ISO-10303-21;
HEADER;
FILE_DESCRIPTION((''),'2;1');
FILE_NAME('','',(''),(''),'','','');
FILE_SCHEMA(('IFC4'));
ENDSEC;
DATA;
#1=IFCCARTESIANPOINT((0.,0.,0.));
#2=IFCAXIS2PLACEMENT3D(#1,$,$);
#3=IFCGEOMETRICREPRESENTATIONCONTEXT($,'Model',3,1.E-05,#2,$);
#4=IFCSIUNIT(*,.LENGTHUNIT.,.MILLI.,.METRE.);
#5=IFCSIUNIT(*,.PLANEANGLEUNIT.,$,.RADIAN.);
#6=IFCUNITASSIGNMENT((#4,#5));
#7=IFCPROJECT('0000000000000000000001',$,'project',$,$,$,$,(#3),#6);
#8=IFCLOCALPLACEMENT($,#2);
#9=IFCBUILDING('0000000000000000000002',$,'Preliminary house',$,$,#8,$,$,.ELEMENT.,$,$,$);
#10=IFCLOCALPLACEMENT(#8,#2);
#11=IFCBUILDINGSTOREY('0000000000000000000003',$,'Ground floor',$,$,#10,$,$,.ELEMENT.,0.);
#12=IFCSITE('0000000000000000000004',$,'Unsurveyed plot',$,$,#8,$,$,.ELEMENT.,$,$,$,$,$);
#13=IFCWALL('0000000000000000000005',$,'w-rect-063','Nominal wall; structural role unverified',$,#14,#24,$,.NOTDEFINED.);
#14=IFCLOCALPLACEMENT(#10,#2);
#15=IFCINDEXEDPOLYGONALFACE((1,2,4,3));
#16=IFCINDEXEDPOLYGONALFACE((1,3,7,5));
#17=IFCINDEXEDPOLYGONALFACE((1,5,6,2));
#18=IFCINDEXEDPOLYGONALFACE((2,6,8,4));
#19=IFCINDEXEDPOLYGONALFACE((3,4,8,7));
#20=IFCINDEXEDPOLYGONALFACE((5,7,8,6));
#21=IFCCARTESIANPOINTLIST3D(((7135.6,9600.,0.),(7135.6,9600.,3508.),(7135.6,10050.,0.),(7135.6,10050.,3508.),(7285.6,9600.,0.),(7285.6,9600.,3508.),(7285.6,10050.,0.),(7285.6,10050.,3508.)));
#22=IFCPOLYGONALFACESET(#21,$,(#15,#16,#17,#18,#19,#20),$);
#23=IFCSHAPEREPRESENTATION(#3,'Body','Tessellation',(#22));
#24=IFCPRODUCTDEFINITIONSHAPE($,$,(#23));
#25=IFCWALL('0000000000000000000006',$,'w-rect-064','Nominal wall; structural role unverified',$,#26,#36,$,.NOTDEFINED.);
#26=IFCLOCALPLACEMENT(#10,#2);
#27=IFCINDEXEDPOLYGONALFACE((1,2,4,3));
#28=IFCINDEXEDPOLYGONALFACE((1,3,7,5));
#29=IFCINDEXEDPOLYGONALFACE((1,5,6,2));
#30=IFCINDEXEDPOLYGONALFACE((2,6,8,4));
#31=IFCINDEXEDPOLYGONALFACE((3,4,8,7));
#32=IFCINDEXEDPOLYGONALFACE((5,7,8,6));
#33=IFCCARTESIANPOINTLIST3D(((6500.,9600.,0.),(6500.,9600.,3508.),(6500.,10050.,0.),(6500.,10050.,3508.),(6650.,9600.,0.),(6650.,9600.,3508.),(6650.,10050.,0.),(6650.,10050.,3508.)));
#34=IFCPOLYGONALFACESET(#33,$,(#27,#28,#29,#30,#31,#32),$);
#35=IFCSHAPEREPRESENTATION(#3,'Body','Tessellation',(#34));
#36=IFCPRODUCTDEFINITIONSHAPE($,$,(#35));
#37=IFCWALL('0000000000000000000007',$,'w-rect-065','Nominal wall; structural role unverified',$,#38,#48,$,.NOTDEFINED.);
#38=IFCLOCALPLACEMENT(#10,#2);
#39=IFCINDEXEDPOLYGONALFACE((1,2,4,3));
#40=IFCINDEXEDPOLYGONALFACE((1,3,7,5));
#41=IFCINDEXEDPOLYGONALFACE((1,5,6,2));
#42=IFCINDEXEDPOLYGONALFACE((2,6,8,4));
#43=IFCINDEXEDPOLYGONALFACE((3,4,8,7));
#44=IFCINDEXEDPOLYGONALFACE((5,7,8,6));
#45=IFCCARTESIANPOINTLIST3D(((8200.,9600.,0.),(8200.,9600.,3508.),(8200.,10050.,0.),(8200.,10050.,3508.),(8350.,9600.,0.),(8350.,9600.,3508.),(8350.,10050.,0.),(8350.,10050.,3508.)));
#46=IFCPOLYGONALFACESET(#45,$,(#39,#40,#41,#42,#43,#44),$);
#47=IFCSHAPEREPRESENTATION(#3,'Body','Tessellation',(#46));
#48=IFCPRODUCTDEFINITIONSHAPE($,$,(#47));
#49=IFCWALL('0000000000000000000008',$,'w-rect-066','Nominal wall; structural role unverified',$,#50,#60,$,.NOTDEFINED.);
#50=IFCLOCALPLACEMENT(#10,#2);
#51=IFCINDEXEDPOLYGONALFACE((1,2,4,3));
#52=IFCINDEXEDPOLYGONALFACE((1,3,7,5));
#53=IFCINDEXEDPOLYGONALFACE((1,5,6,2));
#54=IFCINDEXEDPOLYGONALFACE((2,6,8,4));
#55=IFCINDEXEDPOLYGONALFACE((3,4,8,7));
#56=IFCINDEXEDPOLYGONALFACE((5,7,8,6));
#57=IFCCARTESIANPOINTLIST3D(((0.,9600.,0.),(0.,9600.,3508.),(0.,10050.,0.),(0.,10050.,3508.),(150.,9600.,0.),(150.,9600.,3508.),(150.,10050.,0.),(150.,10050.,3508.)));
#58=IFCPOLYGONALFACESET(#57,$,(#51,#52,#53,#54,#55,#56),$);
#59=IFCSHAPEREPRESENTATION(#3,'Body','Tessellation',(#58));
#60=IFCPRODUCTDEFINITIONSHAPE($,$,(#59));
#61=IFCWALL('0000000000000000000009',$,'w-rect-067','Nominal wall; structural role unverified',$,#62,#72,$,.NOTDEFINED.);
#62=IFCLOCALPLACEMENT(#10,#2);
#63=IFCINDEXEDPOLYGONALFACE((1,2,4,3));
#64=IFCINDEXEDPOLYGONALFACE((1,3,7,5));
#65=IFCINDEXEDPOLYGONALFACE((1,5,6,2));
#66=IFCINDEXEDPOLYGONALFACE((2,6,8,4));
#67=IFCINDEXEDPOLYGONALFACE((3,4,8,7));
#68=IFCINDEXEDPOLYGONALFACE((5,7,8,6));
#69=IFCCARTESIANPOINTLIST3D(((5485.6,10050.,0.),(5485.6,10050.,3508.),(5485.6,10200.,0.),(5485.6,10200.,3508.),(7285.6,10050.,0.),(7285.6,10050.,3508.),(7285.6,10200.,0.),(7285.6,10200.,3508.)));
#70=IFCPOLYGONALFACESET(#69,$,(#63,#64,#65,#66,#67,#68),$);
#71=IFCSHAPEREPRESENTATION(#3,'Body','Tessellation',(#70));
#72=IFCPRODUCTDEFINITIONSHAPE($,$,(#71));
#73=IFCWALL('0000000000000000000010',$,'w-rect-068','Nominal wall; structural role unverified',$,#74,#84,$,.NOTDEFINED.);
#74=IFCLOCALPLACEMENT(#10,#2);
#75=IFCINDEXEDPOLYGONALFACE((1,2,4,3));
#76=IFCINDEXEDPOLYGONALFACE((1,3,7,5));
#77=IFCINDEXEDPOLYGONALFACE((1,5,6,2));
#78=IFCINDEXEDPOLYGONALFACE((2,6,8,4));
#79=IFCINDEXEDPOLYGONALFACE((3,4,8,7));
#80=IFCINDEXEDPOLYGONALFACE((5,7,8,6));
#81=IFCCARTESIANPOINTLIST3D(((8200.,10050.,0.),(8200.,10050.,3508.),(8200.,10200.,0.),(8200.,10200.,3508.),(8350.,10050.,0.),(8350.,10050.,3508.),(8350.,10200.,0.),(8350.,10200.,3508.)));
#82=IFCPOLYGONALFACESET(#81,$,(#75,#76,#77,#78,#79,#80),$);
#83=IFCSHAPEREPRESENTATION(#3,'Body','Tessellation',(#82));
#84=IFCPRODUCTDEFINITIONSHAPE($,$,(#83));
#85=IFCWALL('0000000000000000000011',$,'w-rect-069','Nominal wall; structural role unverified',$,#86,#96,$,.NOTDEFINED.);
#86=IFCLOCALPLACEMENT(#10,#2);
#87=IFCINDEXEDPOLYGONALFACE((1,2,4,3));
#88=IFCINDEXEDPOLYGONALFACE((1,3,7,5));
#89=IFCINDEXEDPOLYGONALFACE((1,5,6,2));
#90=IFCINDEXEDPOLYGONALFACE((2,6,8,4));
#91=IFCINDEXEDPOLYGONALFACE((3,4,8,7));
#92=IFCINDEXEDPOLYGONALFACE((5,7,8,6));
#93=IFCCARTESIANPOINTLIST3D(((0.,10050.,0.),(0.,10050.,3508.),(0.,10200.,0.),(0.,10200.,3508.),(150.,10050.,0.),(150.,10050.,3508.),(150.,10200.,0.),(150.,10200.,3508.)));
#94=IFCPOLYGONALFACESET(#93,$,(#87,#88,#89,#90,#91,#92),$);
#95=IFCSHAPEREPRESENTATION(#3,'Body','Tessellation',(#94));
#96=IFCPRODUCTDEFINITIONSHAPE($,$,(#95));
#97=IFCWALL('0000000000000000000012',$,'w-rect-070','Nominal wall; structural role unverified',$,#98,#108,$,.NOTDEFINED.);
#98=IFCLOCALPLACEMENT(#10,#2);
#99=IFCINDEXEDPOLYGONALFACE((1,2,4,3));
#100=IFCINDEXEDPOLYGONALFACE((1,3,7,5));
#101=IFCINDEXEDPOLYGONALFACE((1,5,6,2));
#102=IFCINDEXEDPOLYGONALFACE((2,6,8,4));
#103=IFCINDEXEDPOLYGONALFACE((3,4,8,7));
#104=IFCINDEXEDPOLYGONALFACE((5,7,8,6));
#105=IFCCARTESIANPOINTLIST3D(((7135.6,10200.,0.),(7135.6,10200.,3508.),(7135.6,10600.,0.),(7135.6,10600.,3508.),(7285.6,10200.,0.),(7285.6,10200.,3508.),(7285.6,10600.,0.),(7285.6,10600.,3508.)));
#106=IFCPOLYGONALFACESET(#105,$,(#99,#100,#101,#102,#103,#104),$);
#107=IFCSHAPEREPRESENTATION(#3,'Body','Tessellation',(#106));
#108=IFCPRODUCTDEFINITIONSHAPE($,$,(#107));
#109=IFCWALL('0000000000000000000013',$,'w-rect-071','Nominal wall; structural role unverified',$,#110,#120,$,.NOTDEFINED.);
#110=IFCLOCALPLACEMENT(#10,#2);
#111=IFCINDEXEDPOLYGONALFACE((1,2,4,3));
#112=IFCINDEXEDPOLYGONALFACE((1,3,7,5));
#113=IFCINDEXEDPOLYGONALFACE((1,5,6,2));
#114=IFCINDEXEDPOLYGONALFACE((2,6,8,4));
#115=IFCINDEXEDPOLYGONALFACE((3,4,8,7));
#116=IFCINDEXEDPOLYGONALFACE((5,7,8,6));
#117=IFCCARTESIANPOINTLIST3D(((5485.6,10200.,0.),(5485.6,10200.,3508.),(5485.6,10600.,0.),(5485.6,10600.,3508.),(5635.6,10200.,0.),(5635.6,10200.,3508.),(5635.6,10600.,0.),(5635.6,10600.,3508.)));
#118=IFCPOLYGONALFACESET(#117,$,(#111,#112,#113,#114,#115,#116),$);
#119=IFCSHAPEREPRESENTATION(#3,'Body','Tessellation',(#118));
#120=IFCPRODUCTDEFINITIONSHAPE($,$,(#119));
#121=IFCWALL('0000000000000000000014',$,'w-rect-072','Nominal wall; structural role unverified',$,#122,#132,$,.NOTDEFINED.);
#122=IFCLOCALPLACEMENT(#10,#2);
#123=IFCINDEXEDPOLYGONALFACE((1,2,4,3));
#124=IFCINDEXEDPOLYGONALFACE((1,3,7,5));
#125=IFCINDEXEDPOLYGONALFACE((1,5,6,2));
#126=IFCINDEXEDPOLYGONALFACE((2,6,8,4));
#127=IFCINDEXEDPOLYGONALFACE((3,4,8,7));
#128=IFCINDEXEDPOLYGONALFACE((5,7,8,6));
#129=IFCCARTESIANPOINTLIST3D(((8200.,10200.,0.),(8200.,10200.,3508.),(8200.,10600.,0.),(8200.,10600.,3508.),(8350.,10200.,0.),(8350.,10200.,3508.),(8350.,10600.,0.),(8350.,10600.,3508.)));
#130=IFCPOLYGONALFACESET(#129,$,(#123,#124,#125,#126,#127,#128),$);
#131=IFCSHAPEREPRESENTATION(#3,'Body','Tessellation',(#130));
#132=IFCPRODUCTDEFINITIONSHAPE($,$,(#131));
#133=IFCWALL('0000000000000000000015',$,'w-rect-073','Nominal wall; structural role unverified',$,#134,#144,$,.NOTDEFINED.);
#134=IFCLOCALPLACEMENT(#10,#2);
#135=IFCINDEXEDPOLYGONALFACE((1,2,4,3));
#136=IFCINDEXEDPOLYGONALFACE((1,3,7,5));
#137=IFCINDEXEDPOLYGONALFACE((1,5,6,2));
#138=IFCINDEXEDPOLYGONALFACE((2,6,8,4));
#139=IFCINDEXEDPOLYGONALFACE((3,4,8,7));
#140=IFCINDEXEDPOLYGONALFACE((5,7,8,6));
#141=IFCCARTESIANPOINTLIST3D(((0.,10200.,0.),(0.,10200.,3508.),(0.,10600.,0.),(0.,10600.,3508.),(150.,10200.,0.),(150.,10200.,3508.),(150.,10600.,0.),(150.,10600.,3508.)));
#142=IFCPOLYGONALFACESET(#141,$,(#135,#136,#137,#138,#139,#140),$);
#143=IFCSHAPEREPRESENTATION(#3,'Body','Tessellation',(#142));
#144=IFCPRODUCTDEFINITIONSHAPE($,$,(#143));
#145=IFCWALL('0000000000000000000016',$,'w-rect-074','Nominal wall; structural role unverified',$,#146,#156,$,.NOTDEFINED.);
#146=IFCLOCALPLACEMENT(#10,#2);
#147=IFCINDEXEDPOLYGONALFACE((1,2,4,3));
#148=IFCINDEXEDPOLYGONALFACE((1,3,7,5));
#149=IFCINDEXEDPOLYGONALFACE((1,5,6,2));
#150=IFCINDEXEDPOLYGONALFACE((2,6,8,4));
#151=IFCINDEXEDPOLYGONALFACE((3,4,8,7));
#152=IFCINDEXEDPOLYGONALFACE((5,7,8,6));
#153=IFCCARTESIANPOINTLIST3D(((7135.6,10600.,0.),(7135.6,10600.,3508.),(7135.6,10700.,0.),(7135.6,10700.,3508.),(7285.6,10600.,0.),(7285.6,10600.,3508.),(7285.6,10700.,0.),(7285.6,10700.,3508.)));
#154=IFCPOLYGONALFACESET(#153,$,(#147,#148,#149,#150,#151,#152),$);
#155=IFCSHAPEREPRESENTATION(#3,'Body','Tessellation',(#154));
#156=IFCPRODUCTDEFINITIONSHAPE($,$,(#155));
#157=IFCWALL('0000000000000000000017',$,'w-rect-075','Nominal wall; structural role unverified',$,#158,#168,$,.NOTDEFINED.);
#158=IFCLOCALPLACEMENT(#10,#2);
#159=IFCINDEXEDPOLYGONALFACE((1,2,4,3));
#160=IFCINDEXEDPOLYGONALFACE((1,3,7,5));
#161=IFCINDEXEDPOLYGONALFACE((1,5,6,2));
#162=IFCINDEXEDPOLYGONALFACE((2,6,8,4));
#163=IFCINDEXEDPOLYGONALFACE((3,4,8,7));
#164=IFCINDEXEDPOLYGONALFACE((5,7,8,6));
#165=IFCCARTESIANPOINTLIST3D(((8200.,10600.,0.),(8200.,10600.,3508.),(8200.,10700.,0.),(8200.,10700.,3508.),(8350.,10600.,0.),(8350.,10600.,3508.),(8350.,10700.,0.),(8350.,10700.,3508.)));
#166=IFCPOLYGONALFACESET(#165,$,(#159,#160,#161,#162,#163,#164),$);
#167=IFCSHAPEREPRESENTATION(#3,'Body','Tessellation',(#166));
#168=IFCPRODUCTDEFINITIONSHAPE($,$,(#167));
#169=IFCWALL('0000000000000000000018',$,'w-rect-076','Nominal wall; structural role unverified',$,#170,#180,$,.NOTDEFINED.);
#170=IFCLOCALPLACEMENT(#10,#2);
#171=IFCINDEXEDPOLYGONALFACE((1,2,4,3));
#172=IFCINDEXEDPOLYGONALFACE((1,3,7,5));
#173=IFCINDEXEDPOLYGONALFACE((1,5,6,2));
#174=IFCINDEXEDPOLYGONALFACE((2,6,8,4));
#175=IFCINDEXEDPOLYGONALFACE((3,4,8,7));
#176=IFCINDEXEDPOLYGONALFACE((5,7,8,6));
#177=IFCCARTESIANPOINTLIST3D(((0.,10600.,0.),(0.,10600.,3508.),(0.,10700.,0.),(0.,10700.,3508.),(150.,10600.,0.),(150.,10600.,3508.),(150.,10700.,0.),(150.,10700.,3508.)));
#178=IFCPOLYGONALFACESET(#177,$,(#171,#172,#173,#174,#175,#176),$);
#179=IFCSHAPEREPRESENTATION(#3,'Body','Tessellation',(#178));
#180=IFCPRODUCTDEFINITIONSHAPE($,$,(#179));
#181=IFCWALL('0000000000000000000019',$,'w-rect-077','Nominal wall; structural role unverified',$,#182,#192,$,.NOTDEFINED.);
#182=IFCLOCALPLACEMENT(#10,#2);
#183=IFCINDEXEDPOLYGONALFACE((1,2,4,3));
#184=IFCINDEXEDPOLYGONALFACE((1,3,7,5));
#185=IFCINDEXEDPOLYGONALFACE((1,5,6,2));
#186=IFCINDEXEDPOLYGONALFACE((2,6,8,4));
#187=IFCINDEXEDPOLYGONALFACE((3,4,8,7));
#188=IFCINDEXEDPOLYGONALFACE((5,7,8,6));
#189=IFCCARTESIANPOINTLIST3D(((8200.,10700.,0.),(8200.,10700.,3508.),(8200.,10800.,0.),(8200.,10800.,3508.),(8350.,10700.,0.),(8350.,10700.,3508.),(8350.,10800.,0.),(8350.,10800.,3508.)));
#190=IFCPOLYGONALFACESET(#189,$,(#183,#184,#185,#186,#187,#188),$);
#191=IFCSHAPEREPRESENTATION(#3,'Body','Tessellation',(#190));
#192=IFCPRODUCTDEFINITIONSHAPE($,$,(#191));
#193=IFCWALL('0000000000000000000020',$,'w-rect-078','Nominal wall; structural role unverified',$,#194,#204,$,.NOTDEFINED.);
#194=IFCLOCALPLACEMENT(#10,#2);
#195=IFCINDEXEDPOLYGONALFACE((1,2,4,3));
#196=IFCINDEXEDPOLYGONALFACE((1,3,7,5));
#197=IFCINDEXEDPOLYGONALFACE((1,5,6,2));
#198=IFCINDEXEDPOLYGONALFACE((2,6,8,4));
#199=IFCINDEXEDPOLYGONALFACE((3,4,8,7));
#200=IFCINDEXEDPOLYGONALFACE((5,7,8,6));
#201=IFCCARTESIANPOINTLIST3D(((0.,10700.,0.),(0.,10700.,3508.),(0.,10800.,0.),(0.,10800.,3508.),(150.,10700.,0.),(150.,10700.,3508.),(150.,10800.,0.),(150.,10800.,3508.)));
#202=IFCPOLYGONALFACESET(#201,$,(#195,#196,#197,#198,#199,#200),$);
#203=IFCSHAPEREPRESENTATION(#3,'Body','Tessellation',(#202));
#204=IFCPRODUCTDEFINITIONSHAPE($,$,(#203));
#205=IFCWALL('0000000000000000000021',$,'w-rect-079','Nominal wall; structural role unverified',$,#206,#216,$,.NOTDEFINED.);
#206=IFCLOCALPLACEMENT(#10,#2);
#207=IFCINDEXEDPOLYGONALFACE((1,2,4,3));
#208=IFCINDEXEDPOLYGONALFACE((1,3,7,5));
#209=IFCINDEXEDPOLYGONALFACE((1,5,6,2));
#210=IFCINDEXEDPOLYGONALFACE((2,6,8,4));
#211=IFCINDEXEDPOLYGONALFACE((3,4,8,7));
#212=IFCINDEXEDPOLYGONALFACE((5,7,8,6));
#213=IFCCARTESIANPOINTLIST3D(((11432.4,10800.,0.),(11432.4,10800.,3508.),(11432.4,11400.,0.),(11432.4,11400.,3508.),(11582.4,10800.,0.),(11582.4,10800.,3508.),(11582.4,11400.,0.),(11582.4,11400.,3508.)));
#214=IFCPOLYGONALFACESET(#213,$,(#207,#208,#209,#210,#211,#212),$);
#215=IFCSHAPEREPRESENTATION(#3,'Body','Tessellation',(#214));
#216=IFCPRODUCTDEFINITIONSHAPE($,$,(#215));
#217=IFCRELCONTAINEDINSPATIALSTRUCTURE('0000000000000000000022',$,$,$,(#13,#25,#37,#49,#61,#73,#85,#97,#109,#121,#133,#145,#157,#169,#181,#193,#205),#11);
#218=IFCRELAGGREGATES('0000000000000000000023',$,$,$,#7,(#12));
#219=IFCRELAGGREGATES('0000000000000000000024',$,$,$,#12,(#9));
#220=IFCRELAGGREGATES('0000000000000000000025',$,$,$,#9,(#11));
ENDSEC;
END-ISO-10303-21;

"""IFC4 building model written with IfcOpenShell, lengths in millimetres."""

from ifc_helpers import new_model, si_unit, origin, place, context, project, spatial, polyline, outline, extrude, element, save


model = new_model("IFC4")

# Units and contexts
model_context = context("Model", 3, precision=1e-05, world=origin())
ifc_project = project(units=[si_unit("LENGTHUNIT", "METRE", prefix="MILLI"), si_unit("PLANEANGLEUNIT", "RADIAN")], contexts=[model_context])

# Site, building, storey
placement_1 = place(None, origin())
site = spatial("IfcSite", under=ifc_project, at=placement_1, Name="Unsurveyed plot", CompositionType="ELEMENT")
building = spatial("IfcBuilding", under=site, at=placement_1, Name="Preliminary house", CompositionType="ELEMENT")
placement_2 = place(placement_1, origin())
storey = spatial("IfcBuildingStorey", under=building, at=placement_2, Name="Ground floor", CompositionType="ELEMENT", Elevation=0.0)

# Walls
element("IfcWall", 1, at=placement_2, inside=storey, Name="w-rect-063", Description="Nominal wall; structural role unverified", PredefinedType="NOTDEFINED", context=model_context, shape_type="SweptSolid", body=[
    extrude(outline(polyline([(7135.6, 9600.0), (7285.6, 9600.0), (7285.6, 10050.0), (7135.6, 10050.0), (7135.6, 9600.0)])), origin(), (0.0, 0.0, 1.0), 3508.0),
])
element("IfcWall", 2, at=placement_2, inside=storey, Name="w-rect-064", Description="Nominal wall; structural role unverified", PredefinedType="NOTDEFINED", context=model_context, shape_type="SweptSolid", body=[
    extrude(outline(polyline([(6500.0, 9600.0), (6650.0, 9600.0), (6650.0, 10050.0), (6500.0, 10050.0), (6500.0, 9600.0)])), origin(), (0.0, 0.0, 1.0), 3508.0),
])
element("IfcWall", 3, at=placement_2, inside=storey, Name="w-rect-065", Description="Nominal wall; structural role unverified", PredefinedType="NOTDEFINED", context=model_context, shape_type="SweptSolid", body=[
    extrude(outline(polyline([(8200.0, 9600.0), (8350.0, 9600.0), (8350.0, 10050.0), (8200.0, 10050.0), (8200.0, 9600.0)])), origin(), (0.0, 0.0, 1.0), 3508.0),
])
element("IfcWall", 4, at=placement_2, inside=storey, Name="w-rect-066", Description="Nominal wall; structural role unverified", PredefinedType="NOTDEFINED", context=model_context, shape_type="SweptSolid", body=[
    extrude(outline(polyline([(0.0, 9600.0), (150.0, 9600.0), (150.0, 10050.0), (0.0, 10050.0), (0.0, 9600.0)])), origin(), (0.0, 0.0, 1.0), 3508.0),
])
element("IfcWall", 5, at=placement_2, inside=storey, Name="w-rect-067", Description="Nominal wall; structural role unverified", PredefinedType="NOTDEFINED", context=model_context, shape_type="SweptSolid", body=[
    extrude(outline(polyline([(5485.6, 10050.0), (7285.6, 10050.0), (7285.6, 10200.0), (5485.6, 10200.0), (5485.6, 10050.0)])), origin(), (0.0, 0.0, 1.0), 3508.0),
])
element("IfcWall", 6, at=placement_2, inside=storey, Name="w-rect-068", Description="Nominal wall; structural role unverified", PredefinedType="NOTDEFINED", context=model_context, shape_type="SweptSolid", body=[
    extrude(outline(polyline([(8200.0, 10050.0), (8350.0, 10050.0), (8350.0, 10200.0), (8200.0, 10200.0), (8200.0, 10050.0)])), origin(), (0.0, 0.0, 1.0), 3508.0),
])
element("IfcWall", 7, at=placement_2, inside=storey, Name="w-rect-069", Description="Nominal wall; structural role unverified", PredefinedType="NOTDEFINED", context=model_context, shape_type="SweptSolid", body=[
    extrude(outline(polyline([(0.0, 10050.0), (150.0, 10050.0), (150.0, 10200.0), (0.0, 10200.0), (0.0, 10050.0)])), origin(), (0.0, 0.0, 1.0), 3508.0),
])
element("IfcWall", 8, at=placement_2, inside=storey, Name="w-rect-070", Description="Nominal wall; structural role unverified", PredefinedType="NOTDEFINED", context=model_context, shape_type="SweptSolid", body=[
    extrude(outline(polyline([(7135.6, 10200.0), (7285.6, 10200.0), (7285.6, 10600.0), (7135.6, 10600.0), (7135.6, 10200.0)])), origin(), (0.0, 0.0, 1.0), 3508.0),
])
element("IfcWall", 9, at=placement_2, inside=storey, Name="w-rect-071", Description="Nominal wall; structural role unverified", PredefinedType="NOTDEFINED", context=model_context, shape_type="SweptSolid", body=[
    extrude(outline(polyline([(5485.6, 10200.0), (5635.6, 10200.0), (5635.6, 10600.0), (5485.6, 10600.0), (5485.6, 10200.0)])), origin(), (0.0, 0.0, 1.0), 3508.0),
])
element("IfcWall", 10, at=placement_2, inside=storey, Name="w-rect-072", Description="Nominal wall; structural role unverified", PredefinedType="NOTDEFINED", context=model_context, shape_type="SweptSolid", body=[
    extrude(outline(polyline([(8200.0, 10200.0), (8350.0, 10200.0), (8350.0, 10600.0), (8200.0, 10600.0), (8200.0, 10200.0)])), origin(), (0.0, 0.0, 1.0), 3508.0),
])
element("IfcWall", 11, at=placement_2, inside=storey, Name="w-rect-073", Description="Nominal wall; structural role unverified", PredefinedType="NOTDEFINED", context=model_context, shape_type="SweptSolid", body=[
    extrude(outline(polyline([(0.0, 10200.0), (150.0, 10200.0), (150.0, 10600.0), (0.0, 10600.0), (0.0, 10200.0)])), origin(), (0.0, 0.0, 1.0), 3508.0),
])
element("IfcWall", 12, at=placement_2, inside=storey, Name="w-rect-074", Description="Nominal wall; structural role unverified", PredefinedType="NOTDEFINED", context=model_context, shape_type="SweptSolid", body=[
    extrude(outline(polyline([(7135.6, 10600.0), (7285.6, 10600.0), (7285.6, 10700.0), (7135.6, 10700.0), (7135.6, 10600.0)])), origin(), (0.0, 0.0, 1.0), 3508.0),
])
element("IfcWall", 13, at=placement_2, inside=storey, Name="w-rect-075", Description="Nominal wall; structural role unverified", PredefinedType="NOTDEFINED", context=model_context, shape_type="SweptSolid", body=[
    extrude(outline(polyline([(8200.0, 10600.0), (8350.0, 10600.0), (8350.0, 10700.0), (8200.0, 10700.0), (8200.0, 10600.0)])), origin(), (0.0, 0.0, 1.0), 3508.0),
])
element("IfcWall", 14, at=placement_2, inside=storey, Name="w-rect-076", Description="Nominal wall; structural role unverified", PredefinedType="NOTDEFINED", context=model_context, shape_type="SweptSolid", body=[
    extrude(outline(polyline([(0.0, 10600.0), (150.0, 10600.0), (150.0, 10700.0), (0.0, 10700.0), (0.0, 10600.0)])), origin(), (0.0, 0.0, 1.0), 3508.0),
])
element("IfcWall", 15, at=placement_2, inside=storey, Name="w-rect-077", Description="Nominal wall; structural role unverified", PredefinedType="NOTDEFINED", context=model_context, shape_type="SweptSolid", body=[
    extrude(outline(polyline([(8200.0, 10700.0), (8350.0, 10700.0), (8350.0, 10800.0), (8200.0, 10800.0), (8200.0, 10700.0)])), origin(), (0.0, 0.0, 1.0), 3508.0),
])
element("IfcWall", 16, at=placement_2, inside=storey, Name="w-rect-078", Description="Nominal wall; structural role unverified", PredefinedType="NOTDEFINED", context=model_context, shape_type="SweptSolid", body=[
    extrude(outline(polyline([(0.0, 10700.0), (150.0, 10700.0), (150.0, 10800.0), (0.0, 10800.0), (0.0, 10700.0)])), origin(), (0.0, 0.0, 1.0), 3508.0),
])
element("IfcWall", 17, at=placement_2, inside=storey, Name="w-rect-079", Description="Nominal wall; structural role unverified", PredefinedType="NOTDEFINED", context=model_context, shape_type="SweptSolid", body=[
    extrude(outline(polyline([(11432.4, 10800.0), (11582.4, 10800.0), (11582.4, 11400.0), (11432.4, 11400.0), (11432.4, 10800.0)])), origin(), (0.0, 0.0, 1.0), 3508.0),
])

save(model, "model.ifc")
